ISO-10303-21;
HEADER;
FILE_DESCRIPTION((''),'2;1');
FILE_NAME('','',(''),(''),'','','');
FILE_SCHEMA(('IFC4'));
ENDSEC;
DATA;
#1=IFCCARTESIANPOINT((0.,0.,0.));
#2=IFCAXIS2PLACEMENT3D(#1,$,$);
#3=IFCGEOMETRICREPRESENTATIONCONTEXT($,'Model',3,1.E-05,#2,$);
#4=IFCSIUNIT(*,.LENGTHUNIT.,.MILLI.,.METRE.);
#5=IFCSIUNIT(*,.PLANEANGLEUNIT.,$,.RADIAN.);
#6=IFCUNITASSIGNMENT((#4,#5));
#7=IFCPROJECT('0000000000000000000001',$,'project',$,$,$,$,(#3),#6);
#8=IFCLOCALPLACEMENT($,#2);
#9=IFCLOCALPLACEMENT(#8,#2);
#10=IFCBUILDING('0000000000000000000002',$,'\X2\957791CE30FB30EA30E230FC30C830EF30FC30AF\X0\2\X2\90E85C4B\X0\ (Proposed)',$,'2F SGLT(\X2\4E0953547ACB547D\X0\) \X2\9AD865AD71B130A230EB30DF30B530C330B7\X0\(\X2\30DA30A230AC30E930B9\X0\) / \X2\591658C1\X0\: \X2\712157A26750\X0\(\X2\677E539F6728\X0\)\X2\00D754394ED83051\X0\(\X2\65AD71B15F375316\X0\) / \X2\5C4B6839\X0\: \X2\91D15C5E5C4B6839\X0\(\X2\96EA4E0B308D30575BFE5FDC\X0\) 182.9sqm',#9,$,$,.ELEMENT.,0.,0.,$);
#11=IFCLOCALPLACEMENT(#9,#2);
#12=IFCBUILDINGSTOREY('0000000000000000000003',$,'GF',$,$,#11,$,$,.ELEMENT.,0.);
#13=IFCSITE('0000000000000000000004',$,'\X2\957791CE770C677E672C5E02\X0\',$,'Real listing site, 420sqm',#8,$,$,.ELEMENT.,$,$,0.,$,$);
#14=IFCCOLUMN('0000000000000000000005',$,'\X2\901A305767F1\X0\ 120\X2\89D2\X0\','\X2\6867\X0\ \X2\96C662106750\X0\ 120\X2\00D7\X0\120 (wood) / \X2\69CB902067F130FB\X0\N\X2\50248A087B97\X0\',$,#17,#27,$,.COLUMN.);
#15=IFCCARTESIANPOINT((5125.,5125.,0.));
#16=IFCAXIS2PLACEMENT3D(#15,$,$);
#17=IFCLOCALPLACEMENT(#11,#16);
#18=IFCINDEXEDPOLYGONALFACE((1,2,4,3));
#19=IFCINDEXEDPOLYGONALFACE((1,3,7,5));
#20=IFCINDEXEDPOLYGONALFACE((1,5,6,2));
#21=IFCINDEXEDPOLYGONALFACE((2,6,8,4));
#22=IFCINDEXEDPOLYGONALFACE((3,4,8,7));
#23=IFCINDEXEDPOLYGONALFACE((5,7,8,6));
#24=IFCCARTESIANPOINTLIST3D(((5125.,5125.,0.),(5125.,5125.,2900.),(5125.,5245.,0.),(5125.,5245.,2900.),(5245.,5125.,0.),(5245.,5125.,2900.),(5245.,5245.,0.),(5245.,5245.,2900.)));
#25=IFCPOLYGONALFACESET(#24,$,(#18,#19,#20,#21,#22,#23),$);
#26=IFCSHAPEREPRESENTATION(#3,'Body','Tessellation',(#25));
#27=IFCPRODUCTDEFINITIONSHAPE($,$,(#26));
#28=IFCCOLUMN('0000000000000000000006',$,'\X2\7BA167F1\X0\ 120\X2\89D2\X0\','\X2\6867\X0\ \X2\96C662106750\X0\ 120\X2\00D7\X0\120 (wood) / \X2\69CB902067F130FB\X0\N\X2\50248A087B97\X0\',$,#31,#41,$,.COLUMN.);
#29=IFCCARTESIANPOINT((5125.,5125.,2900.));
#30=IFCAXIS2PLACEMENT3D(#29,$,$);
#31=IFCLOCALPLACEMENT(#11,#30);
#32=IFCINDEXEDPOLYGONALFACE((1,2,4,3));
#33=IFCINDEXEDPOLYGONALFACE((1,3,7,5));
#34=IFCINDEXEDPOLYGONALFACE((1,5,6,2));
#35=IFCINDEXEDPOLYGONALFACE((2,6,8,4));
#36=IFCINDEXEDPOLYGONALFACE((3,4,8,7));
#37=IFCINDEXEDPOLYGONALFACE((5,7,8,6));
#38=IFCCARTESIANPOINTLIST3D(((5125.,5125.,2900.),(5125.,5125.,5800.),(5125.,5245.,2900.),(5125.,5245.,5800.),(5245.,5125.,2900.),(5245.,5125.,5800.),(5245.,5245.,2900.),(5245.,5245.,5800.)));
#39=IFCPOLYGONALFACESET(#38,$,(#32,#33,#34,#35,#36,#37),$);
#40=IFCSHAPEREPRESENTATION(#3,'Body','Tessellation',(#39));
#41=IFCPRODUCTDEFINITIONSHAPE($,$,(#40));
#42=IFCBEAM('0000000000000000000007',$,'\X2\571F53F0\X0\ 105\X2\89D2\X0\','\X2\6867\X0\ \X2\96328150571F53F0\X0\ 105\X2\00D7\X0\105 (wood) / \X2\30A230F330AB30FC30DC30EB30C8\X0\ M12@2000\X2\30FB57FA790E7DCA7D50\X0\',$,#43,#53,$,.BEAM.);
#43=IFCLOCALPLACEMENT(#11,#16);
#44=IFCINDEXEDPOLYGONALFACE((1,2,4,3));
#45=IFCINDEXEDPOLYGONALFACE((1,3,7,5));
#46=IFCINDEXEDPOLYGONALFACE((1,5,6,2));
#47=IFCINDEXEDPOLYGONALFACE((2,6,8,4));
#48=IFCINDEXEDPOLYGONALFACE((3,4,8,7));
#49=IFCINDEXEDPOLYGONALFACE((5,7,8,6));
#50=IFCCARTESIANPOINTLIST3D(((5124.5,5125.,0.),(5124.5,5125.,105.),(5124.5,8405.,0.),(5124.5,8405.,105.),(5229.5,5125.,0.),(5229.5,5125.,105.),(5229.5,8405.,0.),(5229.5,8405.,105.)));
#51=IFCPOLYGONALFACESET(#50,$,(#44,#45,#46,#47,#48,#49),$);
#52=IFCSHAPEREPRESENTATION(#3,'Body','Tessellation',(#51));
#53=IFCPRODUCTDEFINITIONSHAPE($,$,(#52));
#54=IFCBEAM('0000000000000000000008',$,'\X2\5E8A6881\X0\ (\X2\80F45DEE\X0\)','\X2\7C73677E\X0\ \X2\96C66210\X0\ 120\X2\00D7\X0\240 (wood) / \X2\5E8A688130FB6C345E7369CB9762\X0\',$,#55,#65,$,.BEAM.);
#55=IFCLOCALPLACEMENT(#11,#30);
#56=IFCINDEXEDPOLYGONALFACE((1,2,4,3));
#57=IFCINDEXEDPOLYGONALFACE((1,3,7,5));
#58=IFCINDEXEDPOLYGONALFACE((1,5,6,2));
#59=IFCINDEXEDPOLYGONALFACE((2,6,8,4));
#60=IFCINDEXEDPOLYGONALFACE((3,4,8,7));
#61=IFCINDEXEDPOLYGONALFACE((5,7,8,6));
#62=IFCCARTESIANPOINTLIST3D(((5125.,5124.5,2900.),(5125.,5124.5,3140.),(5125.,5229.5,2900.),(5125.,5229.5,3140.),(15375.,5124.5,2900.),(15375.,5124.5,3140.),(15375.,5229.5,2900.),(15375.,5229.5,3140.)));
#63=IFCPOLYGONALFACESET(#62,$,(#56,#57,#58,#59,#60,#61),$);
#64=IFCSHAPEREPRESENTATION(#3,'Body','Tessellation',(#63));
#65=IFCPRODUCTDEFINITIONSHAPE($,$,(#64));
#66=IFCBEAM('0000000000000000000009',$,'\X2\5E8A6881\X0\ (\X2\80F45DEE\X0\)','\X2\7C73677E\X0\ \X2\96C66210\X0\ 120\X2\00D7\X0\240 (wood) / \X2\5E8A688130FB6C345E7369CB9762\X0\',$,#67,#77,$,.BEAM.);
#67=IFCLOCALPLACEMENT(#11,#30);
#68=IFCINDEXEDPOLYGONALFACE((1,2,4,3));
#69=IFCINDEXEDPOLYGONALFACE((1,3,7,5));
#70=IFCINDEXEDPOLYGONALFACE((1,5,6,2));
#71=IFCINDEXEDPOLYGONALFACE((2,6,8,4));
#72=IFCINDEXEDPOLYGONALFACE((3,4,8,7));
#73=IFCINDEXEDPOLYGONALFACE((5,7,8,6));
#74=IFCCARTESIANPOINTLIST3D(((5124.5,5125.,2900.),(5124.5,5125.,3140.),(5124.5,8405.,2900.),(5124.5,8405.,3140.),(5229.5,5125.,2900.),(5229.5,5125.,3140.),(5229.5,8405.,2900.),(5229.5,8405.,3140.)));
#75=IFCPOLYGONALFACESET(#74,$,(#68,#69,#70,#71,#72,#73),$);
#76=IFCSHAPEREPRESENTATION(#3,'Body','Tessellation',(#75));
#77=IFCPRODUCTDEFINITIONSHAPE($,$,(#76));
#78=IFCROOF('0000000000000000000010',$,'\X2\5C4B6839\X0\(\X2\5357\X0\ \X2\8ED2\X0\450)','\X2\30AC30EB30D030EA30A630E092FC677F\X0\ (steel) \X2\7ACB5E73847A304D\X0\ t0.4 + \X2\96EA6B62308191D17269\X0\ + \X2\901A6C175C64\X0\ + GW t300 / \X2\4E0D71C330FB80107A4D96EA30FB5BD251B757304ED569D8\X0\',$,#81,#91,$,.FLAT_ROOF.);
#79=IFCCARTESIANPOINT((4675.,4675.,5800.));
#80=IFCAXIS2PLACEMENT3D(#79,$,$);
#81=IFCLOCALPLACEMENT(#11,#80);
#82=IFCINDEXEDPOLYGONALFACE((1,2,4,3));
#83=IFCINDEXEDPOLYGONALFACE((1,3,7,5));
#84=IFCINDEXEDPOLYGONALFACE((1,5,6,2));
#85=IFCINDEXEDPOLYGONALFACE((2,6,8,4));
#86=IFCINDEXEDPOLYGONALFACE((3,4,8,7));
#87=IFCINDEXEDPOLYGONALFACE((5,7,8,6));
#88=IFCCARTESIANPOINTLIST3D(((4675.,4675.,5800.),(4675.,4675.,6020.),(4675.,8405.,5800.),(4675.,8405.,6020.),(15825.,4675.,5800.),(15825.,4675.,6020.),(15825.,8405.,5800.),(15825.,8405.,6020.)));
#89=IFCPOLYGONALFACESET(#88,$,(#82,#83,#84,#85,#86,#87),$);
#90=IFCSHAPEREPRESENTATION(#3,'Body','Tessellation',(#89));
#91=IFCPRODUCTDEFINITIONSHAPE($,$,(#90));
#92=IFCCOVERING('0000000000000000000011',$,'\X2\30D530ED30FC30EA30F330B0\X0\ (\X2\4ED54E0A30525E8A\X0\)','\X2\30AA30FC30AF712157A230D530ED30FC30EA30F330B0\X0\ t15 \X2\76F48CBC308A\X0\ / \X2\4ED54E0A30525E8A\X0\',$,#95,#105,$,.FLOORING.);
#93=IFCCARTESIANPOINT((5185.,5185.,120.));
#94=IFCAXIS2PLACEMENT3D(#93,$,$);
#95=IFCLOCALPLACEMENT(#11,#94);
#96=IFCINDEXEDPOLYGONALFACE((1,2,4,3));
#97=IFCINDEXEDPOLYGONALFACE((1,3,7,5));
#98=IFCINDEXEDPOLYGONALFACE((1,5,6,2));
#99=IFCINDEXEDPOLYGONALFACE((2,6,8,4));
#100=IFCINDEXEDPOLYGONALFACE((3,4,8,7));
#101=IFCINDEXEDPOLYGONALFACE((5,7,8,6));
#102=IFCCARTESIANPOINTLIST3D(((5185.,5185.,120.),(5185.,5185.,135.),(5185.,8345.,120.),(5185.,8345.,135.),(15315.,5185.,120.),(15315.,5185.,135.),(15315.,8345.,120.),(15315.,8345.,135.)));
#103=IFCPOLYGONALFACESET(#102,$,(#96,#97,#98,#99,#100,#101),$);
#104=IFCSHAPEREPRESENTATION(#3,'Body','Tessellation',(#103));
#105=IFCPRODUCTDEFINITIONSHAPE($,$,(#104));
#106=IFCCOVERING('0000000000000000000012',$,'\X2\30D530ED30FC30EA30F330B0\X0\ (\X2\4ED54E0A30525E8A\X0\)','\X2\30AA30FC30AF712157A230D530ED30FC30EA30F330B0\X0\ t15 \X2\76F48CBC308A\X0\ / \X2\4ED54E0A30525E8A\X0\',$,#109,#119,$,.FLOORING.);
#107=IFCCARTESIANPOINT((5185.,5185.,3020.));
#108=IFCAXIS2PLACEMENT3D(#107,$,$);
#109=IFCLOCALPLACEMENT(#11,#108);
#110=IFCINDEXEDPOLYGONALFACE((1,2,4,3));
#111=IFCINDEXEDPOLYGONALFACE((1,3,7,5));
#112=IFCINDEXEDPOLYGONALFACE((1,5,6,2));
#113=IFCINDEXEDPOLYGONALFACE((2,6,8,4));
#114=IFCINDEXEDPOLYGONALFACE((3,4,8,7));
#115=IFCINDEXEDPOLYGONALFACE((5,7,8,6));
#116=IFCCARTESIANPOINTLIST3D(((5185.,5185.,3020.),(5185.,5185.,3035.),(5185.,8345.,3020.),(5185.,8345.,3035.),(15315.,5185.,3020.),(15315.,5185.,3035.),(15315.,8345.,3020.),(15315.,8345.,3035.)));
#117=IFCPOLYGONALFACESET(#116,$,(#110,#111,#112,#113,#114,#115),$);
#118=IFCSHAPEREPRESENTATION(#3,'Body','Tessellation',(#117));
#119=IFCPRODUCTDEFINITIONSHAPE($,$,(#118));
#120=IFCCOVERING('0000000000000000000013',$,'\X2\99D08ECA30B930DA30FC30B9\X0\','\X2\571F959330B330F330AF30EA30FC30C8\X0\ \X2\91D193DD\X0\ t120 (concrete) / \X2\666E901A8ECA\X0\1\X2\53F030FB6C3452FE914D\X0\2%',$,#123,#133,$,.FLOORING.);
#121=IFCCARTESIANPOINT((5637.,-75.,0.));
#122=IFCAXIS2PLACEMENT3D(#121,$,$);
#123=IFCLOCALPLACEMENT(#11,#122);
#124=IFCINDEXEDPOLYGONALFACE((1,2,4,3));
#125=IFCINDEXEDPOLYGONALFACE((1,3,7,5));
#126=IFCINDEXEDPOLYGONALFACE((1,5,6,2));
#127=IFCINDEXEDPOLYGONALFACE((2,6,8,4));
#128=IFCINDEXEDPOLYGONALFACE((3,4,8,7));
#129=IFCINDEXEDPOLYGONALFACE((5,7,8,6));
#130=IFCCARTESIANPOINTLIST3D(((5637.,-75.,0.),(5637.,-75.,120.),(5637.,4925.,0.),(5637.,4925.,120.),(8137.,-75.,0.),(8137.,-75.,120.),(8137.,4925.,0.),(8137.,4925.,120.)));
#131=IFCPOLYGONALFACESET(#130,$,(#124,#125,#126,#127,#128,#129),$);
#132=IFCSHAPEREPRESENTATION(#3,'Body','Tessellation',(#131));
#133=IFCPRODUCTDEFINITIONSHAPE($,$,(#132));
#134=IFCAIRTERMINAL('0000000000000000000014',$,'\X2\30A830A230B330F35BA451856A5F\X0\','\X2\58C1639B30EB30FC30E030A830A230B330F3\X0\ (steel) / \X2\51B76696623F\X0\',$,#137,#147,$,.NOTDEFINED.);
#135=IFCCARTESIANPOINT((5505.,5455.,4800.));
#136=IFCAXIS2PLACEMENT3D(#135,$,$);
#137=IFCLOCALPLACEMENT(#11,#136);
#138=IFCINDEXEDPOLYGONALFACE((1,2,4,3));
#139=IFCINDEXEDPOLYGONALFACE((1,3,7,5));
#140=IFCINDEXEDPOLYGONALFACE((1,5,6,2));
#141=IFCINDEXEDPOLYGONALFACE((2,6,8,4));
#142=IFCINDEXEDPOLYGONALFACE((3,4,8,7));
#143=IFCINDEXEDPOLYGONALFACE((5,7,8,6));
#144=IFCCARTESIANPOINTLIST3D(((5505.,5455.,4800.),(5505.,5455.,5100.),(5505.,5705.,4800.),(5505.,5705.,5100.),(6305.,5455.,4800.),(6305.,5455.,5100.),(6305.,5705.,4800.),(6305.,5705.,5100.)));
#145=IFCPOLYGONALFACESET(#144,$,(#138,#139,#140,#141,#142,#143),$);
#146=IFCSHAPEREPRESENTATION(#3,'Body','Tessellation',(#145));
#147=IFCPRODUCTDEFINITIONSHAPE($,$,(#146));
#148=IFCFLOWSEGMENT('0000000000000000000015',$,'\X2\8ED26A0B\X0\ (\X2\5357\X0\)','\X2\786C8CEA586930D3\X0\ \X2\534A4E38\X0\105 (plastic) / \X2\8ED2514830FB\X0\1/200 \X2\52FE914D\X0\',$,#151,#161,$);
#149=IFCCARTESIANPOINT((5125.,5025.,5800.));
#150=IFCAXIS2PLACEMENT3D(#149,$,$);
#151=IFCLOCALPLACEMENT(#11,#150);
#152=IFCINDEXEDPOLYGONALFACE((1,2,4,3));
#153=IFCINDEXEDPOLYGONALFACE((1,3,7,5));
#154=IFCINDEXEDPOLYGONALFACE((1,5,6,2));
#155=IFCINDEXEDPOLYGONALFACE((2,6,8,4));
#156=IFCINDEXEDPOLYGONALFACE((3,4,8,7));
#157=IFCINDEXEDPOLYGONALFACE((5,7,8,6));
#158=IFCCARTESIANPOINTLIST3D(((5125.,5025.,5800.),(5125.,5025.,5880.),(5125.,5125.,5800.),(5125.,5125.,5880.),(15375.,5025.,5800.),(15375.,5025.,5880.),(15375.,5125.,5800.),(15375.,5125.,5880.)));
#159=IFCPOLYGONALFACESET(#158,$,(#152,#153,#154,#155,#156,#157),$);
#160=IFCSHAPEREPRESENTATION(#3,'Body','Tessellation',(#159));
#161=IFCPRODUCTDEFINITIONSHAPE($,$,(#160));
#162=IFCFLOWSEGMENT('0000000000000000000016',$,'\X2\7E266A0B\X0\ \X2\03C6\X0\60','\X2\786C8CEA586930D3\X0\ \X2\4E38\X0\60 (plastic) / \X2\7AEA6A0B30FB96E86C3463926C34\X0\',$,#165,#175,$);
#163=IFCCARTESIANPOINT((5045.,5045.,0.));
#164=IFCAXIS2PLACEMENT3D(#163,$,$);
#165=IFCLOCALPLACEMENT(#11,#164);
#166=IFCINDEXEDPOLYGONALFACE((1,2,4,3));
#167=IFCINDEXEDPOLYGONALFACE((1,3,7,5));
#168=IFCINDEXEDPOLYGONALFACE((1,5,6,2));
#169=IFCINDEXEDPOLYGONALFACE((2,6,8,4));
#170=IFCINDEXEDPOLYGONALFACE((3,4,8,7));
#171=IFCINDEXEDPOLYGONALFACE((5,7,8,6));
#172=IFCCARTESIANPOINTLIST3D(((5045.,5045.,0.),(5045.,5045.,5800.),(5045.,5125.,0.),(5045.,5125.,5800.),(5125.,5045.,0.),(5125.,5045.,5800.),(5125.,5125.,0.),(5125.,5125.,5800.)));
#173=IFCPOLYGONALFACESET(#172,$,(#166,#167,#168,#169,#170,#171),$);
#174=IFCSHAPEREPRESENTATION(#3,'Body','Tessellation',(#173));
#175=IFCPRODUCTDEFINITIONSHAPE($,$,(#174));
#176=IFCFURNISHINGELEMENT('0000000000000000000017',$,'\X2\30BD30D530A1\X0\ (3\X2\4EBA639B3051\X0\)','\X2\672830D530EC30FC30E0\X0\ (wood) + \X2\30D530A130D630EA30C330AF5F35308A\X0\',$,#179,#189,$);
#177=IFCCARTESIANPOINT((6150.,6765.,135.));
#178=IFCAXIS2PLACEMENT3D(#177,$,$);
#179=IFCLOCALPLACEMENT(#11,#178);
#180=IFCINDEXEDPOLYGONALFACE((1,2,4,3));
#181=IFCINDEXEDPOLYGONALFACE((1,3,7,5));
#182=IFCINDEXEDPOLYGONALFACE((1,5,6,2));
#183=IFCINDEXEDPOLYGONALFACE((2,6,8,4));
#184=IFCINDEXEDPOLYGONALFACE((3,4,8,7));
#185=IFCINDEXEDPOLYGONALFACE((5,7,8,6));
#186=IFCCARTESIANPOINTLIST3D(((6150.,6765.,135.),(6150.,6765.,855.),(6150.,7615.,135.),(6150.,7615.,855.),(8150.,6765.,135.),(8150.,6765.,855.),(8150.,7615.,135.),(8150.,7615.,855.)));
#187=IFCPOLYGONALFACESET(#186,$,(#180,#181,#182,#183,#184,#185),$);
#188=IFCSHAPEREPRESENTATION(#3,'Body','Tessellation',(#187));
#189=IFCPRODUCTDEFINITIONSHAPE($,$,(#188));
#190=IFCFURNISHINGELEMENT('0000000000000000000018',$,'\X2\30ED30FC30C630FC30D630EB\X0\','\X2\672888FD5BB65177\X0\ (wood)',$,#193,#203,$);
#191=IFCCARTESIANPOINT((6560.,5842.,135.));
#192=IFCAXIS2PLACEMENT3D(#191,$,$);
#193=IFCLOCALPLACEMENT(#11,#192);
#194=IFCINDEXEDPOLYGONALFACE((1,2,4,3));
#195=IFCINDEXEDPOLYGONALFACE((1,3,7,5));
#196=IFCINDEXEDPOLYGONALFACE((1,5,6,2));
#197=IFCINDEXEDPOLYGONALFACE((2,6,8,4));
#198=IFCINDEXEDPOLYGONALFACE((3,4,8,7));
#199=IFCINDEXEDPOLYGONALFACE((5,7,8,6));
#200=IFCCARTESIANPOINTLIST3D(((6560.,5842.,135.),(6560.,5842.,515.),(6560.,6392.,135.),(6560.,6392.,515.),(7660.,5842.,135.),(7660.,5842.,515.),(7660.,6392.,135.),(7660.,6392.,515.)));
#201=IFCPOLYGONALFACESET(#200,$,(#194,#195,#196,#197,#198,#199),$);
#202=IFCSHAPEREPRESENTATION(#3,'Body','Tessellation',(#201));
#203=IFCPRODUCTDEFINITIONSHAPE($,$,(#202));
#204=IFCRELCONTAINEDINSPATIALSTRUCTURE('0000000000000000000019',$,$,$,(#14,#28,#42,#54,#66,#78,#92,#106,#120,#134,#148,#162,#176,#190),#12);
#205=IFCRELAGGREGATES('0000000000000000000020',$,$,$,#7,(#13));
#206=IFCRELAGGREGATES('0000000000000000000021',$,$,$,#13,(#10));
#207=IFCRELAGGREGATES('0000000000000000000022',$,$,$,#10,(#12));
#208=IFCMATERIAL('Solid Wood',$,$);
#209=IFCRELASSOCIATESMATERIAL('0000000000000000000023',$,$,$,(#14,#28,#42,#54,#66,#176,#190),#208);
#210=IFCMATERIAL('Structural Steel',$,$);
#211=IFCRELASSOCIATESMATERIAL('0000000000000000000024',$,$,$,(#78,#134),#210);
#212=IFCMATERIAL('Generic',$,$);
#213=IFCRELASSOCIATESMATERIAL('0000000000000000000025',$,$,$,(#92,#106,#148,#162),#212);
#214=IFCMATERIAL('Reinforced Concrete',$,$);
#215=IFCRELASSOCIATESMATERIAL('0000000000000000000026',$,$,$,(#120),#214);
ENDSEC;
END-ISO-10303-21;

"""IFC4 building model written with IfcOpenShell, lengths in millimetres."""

from ifc_helpers import new_model, si_unit, frame, frame_2d, origin, place, context, project, spatial, rectangle, extrude, material, element, save


model = new_model("IFC4")

# Units and contexts
model_context = context("Model", 3, precision=1e-05, world=origin())
ifc_project = project(units=[si_unit("LENGTHUNIT", "METRE", prefix="MILLI"), si_unit("PLANEANGLEUNIT", "RADIAN")], contexts=[model_context])

# Site, building, storey
site_placement = place(None, origin())
site = spatial("IfcSite", under=ifc_project, at=site_placement, Name="長野県松本市", ObjectType="Real listing site, 420sqm", CompositionType="ELEMENT", RefElevation=0.0)
building_placement = place(site_placement, origin())
building = spatial("IfcBuilding", under=site, at=building_placement, Name="長野・リモートワーク2部屋 (Proposed)", ObjectType="2F SGLT(三協立命) 高断熱アルミサッシ(ペアガラス) / 外壁: 無垢材(松原木)×吹付け(断熱強化) / 屋根: 金属屋根(雪下ろし対応) 182.9sqm", CompositionType="ELEMENT", ElevationOfRefHeight=0.0, ElevationOfTerrain=0.0)
storey_placement = place(building_placement, origin())
storey = spatial("IfcBuildingStorey", under=building, at=storey_placement, Name="GF", CompositionType="ELEMENT", Elevation=0.0)

# Columns
ifc_material_1 = material(Name="Solid Wood")
column_1_placement = place(storey_placement, frame((5125.0, 5125.0, 0.0)))
element("IfcColumn", 1, at=column_1_placement, inside=storey, material=ifc_material_1, Name="通し柱 120角", Description="桧 集成材 120×120 (wood) / 構造柱・N値計算", PredefinedType="COLUMN", context=model_context, shape_type="SweptSolid", body=[
    extrude(rectangle(XDim=120.0, YDim=120.0, at=frame_2d((60.0, 60.0))), frame((5125.0, 5125.0, 0.0)), (0.0, 0.0, 1.0), 2900.0),
])
column_2_placement = place(storey_placement, frame((5125.0, 5125.0, 2900.0)))
element("IfcColumn", 2, at=column_2_placement, inside=storey, material=ifc_material_1, Name="管柱 120角", Description="桧 集成材 120×120 (wood) / 構造柱・N値計算", PredefinedType="COLUMN", context=model_context, shape_type="SweptSolid", body=[
    extrude(rectangle(XDim=120.0, YDim=120.0, at=frame_2d((60.0, 60.0))), frame((5125.0, 5125.0, 2900.0)), (0.0, 0.0, 1.0), 2900.0),
])

# Beams
beam_1_placement = place(storey_placement, frame((5125.0, 5125.0, 0.0)))
element("IfcBeam", 3, at=beam_1_placement, inside=storey, material=ifc_material_1, Name="土台 105角", Description="桧 防腐土台 105×105 (wood) / アンカーボルト M12@2000・基礎緊結", PredefinedType="BEAM", context=model_context, shape_type="SweptSolid", body=[
    extrude(rectangle(XDim=105.0, YDim=3280.0, at=frame_2d((52.0, 1640.0))), frame((5125.0, 5125.0, 0.0)), (0.0, 0.0, 1.0), 105.0),
])
beam_2_placement = place(storey_placement, frame((5125.0, 5125.0, 2900.0)))
element("IfcBeam", 4, at=beam_2_placement, inside=storey, material=ifc_material_1, Name="床梁 (胴差)", Description="米松 集成 120×240 (wood) / 床梁・水平構面", PredefinedType="BEAM", context=model_context, shape_type="SweptSolid", body=[
    extrude(rectangle(XDim=10250.0, YDim=105.0, at=frame_2d((5125.0, 52.0))), frame((5125.0, 5125.0, 2900.0)), (0.0, 0.0, 1.0), 240.0),
])
beam_3_placement = place(storey_placement, frame((5125.0, 5125.0, 2900.0)))
element("IfcBeam", 5, at=beam_3_placement, inside=storey, material=ifc_material_1, Name="床梁 (胴差)", Description="米松 集成 120×240 (wood) / 床梁・水平構面", PredefinedType="BEAM", context=model_context, shape_type="SweptSolid", body=[
    extrude(rectangle(XDim=105.0, YDim=3280.0, at=frame_2d((52.0, 1640.0))), frame((5125.0, 5125.0, 2900.0)), (0.0, 0.0, 1.0), 240.0),
])

# Shared definitions
ifc_material_2 = material(Name="Reinforced Concrete")

# Roof
ifc_material_3 = material(Name="Structural Steel")
for number, where, name in (
    (6, (4675.0, 4675.0, 5800.0), "屋根(南 軒450)"),
):
    element("IfcRoof", number, at=place(storey_placement, frame(where)), inside=storey, material=ifc_material_3, Name=name, Description="ガルバリウム鋼板 (steel) 立平葺き t0.4 + 雪止め金物 + 通気層 + GW t300 / 不燃・耐積雪・寒冷地仕様", PredefinedType="FLAT_ROOF", context=model_context, shape_type="SweptSolid", body=[
        extrude(rectangle(XDim=11150.0, YDim=3730.0, at=frame_2d((5575.0, 1865.0))), frame((4675.0, 4675.0, 5800.0)), (0.0, 0.0, 1.0), 220.0),
    ])

# Coverings
ifc_material_4 = material(Name="Generic")
covering_1_placement = place(storey_placement, frame((5185.0, 5185.0, 120.0)))
element("IfcCovering", 7, at=covering_1_placement, inside=storey, material=ifc_material_4, Name="フローリング (仕上げ床)", Description="オーク無垢フローリング t15 直貼り / 仕上げ床", PredefinedType="FLOORING", context=model_context, shape_type="SweptSolid", body=[
    extrude(rectangle(XDim=10130.0, YDim=3160.0, at=frame_2d((5065.0, 1580.0))), frame((5185.0, 5185.0, 120.0)), (0.0, 0.0, 1.0), 15.0),
])
covering_2_placement = place(storey_placement, frame((5185.0, 5185.0, 3020.0)))
element("IfcCovering", 8, at=covering_2_placement, inside=storey, material=ifc_material_4, Name="フローリング (仕上げ床)", Description="オーク無垢フローリング t15 直貼り / 仕上げ床", PredefinedType="FLOORING", context=model_context, shape_type="SweptSolid", body=[
    extrude(rectangle(XDim=10130.0, YDim=3160.0, at=frame_2d((5065.0, 1580.0))), frame((5185.0, 5185.0, 3020.0)), (0.0, 0.0, 1.0), 15.0),
])
covering_3_placement = place(storey_placement, frame((5637.0, -75.0, 0.0)))
element("IfcCovering", 9, at=covering_3_placement, inside=storey, material=ifc_material_2, Name="駐車スペース", Description="土間コンクリート 金鏝 t120 (concrete) / 普通車1台・水勾配2%", PredefinedType="FLOORING", context=model_context, shape_type="SweptSolid", body=[
    extrude(rectangle(XDim=2500.0, YDim=5000.0, at=frame_2d((1250.0, 2500.0))), frame((5637.0, -75.0, 0.0)), (0.0, 0.0, 1.0), 120.0),
])

# Air terminal
air_terminal_placement = place(storey_placement, frame((5505.0, 5455.0, 4800.0)))
element("IfcAirTerminal", 10, at=air_terminal_placement, inside=storey, material=ifc_material_3, Name="エアコン室内機", Description="壁掛ルームエアコン (steel) / 冷暖房", PredefinedType="NOTDEFINED", context=model_context, shape_type="SweptSolid", body=[
    extrude(rectangle(XDim=800.0, YDim=250.0, at=frame_2d((400.0, 125.0))), frame((5505.0, 5455.0, 4800.0)), (0.0, 0.0, 1.0), 300.0),
])

# Flow segments
flow_segment_1_placement = place(storey_placement, frame((5125.0, 5025.0, 5800.0)))
element("IfcFlowSegment", 11, at=flow_segment_1_placement, inside=storey, material=ifc_material_4, Name="軒樋 (南)", Description="硬質塩ビ 半丸105 (plastic) / 軒先・1/200 勾配", context=model_context, shape_type="SweptSolid", body=[
    extrude(rectangle(XDim=10250.0, YDim=100.0, at=frame_2d((5125.0, 50.0))), frame((5125.0, 5025.0, 5800.0)), (0.0, 0.0, 1.0), 80.0),
])
flow_segment_2_placement = place(storey_placement, frame((5045.0, 5045.0, 0.0)))
element("IfcFlowSegment", 12, at=flow_segment_2_placement, inside=storey, material=ifc_material_4, Name="縦樋 φ60", Description="硬質塩ビ 丸60 (plastic) / 竪樋・雨水排水", context=model_context, shape_type="SweptSolid", body=[
    extrude(rectangle(XDim=80.0, YDim=80.0, at=frame_2d((40.0, 40.0))), frame((5045.0, 5045.0, 0.0)), (0.0, 0.0, 1.0), 5800.0),
])

# Furnishing elements
furnishing_1_placement = place(storey_placement, frame((6150.0, 6765.0, 135.0)))
element("IfcFurnishingElement", 13, at=furnishing_1_placement, inside=storey, material=ifc_material_1, Name="ソファ (3人掛け)", Description="木フレーム (wood) + ファブリック張り", context=model_context, shape_type="SweptSolid", body=[
    extrude(rectangle(XDim=2000.0, YDim=850.0, at=frame_2d((1000.0, 425.0))), frame((6150.0, 6765.0, 135.0)), (0.0, 0.0, 1.0), 720.0),
])
furnishing_2_placement = place(storey_placement, frame((6560.0, 5842.0, 135.0)))
element("IfcFurnishingElement", 14, at=furnishing_2_placement, inside=storey, material=ifc_material_1, Name="ローテーブル", Description="木製家具 (wood)", context=model_context, shape_type="SweptSolid", body=[
    extrude(rectangle(XDim=1100.0, YDim=550.0, at=frame_2d((550.0, 275.0))), frame((6560.0, 5842.0, 135.0)), (0.0, 0.0, 1.0), 380.0),
])

save(model, "model.ifc")
